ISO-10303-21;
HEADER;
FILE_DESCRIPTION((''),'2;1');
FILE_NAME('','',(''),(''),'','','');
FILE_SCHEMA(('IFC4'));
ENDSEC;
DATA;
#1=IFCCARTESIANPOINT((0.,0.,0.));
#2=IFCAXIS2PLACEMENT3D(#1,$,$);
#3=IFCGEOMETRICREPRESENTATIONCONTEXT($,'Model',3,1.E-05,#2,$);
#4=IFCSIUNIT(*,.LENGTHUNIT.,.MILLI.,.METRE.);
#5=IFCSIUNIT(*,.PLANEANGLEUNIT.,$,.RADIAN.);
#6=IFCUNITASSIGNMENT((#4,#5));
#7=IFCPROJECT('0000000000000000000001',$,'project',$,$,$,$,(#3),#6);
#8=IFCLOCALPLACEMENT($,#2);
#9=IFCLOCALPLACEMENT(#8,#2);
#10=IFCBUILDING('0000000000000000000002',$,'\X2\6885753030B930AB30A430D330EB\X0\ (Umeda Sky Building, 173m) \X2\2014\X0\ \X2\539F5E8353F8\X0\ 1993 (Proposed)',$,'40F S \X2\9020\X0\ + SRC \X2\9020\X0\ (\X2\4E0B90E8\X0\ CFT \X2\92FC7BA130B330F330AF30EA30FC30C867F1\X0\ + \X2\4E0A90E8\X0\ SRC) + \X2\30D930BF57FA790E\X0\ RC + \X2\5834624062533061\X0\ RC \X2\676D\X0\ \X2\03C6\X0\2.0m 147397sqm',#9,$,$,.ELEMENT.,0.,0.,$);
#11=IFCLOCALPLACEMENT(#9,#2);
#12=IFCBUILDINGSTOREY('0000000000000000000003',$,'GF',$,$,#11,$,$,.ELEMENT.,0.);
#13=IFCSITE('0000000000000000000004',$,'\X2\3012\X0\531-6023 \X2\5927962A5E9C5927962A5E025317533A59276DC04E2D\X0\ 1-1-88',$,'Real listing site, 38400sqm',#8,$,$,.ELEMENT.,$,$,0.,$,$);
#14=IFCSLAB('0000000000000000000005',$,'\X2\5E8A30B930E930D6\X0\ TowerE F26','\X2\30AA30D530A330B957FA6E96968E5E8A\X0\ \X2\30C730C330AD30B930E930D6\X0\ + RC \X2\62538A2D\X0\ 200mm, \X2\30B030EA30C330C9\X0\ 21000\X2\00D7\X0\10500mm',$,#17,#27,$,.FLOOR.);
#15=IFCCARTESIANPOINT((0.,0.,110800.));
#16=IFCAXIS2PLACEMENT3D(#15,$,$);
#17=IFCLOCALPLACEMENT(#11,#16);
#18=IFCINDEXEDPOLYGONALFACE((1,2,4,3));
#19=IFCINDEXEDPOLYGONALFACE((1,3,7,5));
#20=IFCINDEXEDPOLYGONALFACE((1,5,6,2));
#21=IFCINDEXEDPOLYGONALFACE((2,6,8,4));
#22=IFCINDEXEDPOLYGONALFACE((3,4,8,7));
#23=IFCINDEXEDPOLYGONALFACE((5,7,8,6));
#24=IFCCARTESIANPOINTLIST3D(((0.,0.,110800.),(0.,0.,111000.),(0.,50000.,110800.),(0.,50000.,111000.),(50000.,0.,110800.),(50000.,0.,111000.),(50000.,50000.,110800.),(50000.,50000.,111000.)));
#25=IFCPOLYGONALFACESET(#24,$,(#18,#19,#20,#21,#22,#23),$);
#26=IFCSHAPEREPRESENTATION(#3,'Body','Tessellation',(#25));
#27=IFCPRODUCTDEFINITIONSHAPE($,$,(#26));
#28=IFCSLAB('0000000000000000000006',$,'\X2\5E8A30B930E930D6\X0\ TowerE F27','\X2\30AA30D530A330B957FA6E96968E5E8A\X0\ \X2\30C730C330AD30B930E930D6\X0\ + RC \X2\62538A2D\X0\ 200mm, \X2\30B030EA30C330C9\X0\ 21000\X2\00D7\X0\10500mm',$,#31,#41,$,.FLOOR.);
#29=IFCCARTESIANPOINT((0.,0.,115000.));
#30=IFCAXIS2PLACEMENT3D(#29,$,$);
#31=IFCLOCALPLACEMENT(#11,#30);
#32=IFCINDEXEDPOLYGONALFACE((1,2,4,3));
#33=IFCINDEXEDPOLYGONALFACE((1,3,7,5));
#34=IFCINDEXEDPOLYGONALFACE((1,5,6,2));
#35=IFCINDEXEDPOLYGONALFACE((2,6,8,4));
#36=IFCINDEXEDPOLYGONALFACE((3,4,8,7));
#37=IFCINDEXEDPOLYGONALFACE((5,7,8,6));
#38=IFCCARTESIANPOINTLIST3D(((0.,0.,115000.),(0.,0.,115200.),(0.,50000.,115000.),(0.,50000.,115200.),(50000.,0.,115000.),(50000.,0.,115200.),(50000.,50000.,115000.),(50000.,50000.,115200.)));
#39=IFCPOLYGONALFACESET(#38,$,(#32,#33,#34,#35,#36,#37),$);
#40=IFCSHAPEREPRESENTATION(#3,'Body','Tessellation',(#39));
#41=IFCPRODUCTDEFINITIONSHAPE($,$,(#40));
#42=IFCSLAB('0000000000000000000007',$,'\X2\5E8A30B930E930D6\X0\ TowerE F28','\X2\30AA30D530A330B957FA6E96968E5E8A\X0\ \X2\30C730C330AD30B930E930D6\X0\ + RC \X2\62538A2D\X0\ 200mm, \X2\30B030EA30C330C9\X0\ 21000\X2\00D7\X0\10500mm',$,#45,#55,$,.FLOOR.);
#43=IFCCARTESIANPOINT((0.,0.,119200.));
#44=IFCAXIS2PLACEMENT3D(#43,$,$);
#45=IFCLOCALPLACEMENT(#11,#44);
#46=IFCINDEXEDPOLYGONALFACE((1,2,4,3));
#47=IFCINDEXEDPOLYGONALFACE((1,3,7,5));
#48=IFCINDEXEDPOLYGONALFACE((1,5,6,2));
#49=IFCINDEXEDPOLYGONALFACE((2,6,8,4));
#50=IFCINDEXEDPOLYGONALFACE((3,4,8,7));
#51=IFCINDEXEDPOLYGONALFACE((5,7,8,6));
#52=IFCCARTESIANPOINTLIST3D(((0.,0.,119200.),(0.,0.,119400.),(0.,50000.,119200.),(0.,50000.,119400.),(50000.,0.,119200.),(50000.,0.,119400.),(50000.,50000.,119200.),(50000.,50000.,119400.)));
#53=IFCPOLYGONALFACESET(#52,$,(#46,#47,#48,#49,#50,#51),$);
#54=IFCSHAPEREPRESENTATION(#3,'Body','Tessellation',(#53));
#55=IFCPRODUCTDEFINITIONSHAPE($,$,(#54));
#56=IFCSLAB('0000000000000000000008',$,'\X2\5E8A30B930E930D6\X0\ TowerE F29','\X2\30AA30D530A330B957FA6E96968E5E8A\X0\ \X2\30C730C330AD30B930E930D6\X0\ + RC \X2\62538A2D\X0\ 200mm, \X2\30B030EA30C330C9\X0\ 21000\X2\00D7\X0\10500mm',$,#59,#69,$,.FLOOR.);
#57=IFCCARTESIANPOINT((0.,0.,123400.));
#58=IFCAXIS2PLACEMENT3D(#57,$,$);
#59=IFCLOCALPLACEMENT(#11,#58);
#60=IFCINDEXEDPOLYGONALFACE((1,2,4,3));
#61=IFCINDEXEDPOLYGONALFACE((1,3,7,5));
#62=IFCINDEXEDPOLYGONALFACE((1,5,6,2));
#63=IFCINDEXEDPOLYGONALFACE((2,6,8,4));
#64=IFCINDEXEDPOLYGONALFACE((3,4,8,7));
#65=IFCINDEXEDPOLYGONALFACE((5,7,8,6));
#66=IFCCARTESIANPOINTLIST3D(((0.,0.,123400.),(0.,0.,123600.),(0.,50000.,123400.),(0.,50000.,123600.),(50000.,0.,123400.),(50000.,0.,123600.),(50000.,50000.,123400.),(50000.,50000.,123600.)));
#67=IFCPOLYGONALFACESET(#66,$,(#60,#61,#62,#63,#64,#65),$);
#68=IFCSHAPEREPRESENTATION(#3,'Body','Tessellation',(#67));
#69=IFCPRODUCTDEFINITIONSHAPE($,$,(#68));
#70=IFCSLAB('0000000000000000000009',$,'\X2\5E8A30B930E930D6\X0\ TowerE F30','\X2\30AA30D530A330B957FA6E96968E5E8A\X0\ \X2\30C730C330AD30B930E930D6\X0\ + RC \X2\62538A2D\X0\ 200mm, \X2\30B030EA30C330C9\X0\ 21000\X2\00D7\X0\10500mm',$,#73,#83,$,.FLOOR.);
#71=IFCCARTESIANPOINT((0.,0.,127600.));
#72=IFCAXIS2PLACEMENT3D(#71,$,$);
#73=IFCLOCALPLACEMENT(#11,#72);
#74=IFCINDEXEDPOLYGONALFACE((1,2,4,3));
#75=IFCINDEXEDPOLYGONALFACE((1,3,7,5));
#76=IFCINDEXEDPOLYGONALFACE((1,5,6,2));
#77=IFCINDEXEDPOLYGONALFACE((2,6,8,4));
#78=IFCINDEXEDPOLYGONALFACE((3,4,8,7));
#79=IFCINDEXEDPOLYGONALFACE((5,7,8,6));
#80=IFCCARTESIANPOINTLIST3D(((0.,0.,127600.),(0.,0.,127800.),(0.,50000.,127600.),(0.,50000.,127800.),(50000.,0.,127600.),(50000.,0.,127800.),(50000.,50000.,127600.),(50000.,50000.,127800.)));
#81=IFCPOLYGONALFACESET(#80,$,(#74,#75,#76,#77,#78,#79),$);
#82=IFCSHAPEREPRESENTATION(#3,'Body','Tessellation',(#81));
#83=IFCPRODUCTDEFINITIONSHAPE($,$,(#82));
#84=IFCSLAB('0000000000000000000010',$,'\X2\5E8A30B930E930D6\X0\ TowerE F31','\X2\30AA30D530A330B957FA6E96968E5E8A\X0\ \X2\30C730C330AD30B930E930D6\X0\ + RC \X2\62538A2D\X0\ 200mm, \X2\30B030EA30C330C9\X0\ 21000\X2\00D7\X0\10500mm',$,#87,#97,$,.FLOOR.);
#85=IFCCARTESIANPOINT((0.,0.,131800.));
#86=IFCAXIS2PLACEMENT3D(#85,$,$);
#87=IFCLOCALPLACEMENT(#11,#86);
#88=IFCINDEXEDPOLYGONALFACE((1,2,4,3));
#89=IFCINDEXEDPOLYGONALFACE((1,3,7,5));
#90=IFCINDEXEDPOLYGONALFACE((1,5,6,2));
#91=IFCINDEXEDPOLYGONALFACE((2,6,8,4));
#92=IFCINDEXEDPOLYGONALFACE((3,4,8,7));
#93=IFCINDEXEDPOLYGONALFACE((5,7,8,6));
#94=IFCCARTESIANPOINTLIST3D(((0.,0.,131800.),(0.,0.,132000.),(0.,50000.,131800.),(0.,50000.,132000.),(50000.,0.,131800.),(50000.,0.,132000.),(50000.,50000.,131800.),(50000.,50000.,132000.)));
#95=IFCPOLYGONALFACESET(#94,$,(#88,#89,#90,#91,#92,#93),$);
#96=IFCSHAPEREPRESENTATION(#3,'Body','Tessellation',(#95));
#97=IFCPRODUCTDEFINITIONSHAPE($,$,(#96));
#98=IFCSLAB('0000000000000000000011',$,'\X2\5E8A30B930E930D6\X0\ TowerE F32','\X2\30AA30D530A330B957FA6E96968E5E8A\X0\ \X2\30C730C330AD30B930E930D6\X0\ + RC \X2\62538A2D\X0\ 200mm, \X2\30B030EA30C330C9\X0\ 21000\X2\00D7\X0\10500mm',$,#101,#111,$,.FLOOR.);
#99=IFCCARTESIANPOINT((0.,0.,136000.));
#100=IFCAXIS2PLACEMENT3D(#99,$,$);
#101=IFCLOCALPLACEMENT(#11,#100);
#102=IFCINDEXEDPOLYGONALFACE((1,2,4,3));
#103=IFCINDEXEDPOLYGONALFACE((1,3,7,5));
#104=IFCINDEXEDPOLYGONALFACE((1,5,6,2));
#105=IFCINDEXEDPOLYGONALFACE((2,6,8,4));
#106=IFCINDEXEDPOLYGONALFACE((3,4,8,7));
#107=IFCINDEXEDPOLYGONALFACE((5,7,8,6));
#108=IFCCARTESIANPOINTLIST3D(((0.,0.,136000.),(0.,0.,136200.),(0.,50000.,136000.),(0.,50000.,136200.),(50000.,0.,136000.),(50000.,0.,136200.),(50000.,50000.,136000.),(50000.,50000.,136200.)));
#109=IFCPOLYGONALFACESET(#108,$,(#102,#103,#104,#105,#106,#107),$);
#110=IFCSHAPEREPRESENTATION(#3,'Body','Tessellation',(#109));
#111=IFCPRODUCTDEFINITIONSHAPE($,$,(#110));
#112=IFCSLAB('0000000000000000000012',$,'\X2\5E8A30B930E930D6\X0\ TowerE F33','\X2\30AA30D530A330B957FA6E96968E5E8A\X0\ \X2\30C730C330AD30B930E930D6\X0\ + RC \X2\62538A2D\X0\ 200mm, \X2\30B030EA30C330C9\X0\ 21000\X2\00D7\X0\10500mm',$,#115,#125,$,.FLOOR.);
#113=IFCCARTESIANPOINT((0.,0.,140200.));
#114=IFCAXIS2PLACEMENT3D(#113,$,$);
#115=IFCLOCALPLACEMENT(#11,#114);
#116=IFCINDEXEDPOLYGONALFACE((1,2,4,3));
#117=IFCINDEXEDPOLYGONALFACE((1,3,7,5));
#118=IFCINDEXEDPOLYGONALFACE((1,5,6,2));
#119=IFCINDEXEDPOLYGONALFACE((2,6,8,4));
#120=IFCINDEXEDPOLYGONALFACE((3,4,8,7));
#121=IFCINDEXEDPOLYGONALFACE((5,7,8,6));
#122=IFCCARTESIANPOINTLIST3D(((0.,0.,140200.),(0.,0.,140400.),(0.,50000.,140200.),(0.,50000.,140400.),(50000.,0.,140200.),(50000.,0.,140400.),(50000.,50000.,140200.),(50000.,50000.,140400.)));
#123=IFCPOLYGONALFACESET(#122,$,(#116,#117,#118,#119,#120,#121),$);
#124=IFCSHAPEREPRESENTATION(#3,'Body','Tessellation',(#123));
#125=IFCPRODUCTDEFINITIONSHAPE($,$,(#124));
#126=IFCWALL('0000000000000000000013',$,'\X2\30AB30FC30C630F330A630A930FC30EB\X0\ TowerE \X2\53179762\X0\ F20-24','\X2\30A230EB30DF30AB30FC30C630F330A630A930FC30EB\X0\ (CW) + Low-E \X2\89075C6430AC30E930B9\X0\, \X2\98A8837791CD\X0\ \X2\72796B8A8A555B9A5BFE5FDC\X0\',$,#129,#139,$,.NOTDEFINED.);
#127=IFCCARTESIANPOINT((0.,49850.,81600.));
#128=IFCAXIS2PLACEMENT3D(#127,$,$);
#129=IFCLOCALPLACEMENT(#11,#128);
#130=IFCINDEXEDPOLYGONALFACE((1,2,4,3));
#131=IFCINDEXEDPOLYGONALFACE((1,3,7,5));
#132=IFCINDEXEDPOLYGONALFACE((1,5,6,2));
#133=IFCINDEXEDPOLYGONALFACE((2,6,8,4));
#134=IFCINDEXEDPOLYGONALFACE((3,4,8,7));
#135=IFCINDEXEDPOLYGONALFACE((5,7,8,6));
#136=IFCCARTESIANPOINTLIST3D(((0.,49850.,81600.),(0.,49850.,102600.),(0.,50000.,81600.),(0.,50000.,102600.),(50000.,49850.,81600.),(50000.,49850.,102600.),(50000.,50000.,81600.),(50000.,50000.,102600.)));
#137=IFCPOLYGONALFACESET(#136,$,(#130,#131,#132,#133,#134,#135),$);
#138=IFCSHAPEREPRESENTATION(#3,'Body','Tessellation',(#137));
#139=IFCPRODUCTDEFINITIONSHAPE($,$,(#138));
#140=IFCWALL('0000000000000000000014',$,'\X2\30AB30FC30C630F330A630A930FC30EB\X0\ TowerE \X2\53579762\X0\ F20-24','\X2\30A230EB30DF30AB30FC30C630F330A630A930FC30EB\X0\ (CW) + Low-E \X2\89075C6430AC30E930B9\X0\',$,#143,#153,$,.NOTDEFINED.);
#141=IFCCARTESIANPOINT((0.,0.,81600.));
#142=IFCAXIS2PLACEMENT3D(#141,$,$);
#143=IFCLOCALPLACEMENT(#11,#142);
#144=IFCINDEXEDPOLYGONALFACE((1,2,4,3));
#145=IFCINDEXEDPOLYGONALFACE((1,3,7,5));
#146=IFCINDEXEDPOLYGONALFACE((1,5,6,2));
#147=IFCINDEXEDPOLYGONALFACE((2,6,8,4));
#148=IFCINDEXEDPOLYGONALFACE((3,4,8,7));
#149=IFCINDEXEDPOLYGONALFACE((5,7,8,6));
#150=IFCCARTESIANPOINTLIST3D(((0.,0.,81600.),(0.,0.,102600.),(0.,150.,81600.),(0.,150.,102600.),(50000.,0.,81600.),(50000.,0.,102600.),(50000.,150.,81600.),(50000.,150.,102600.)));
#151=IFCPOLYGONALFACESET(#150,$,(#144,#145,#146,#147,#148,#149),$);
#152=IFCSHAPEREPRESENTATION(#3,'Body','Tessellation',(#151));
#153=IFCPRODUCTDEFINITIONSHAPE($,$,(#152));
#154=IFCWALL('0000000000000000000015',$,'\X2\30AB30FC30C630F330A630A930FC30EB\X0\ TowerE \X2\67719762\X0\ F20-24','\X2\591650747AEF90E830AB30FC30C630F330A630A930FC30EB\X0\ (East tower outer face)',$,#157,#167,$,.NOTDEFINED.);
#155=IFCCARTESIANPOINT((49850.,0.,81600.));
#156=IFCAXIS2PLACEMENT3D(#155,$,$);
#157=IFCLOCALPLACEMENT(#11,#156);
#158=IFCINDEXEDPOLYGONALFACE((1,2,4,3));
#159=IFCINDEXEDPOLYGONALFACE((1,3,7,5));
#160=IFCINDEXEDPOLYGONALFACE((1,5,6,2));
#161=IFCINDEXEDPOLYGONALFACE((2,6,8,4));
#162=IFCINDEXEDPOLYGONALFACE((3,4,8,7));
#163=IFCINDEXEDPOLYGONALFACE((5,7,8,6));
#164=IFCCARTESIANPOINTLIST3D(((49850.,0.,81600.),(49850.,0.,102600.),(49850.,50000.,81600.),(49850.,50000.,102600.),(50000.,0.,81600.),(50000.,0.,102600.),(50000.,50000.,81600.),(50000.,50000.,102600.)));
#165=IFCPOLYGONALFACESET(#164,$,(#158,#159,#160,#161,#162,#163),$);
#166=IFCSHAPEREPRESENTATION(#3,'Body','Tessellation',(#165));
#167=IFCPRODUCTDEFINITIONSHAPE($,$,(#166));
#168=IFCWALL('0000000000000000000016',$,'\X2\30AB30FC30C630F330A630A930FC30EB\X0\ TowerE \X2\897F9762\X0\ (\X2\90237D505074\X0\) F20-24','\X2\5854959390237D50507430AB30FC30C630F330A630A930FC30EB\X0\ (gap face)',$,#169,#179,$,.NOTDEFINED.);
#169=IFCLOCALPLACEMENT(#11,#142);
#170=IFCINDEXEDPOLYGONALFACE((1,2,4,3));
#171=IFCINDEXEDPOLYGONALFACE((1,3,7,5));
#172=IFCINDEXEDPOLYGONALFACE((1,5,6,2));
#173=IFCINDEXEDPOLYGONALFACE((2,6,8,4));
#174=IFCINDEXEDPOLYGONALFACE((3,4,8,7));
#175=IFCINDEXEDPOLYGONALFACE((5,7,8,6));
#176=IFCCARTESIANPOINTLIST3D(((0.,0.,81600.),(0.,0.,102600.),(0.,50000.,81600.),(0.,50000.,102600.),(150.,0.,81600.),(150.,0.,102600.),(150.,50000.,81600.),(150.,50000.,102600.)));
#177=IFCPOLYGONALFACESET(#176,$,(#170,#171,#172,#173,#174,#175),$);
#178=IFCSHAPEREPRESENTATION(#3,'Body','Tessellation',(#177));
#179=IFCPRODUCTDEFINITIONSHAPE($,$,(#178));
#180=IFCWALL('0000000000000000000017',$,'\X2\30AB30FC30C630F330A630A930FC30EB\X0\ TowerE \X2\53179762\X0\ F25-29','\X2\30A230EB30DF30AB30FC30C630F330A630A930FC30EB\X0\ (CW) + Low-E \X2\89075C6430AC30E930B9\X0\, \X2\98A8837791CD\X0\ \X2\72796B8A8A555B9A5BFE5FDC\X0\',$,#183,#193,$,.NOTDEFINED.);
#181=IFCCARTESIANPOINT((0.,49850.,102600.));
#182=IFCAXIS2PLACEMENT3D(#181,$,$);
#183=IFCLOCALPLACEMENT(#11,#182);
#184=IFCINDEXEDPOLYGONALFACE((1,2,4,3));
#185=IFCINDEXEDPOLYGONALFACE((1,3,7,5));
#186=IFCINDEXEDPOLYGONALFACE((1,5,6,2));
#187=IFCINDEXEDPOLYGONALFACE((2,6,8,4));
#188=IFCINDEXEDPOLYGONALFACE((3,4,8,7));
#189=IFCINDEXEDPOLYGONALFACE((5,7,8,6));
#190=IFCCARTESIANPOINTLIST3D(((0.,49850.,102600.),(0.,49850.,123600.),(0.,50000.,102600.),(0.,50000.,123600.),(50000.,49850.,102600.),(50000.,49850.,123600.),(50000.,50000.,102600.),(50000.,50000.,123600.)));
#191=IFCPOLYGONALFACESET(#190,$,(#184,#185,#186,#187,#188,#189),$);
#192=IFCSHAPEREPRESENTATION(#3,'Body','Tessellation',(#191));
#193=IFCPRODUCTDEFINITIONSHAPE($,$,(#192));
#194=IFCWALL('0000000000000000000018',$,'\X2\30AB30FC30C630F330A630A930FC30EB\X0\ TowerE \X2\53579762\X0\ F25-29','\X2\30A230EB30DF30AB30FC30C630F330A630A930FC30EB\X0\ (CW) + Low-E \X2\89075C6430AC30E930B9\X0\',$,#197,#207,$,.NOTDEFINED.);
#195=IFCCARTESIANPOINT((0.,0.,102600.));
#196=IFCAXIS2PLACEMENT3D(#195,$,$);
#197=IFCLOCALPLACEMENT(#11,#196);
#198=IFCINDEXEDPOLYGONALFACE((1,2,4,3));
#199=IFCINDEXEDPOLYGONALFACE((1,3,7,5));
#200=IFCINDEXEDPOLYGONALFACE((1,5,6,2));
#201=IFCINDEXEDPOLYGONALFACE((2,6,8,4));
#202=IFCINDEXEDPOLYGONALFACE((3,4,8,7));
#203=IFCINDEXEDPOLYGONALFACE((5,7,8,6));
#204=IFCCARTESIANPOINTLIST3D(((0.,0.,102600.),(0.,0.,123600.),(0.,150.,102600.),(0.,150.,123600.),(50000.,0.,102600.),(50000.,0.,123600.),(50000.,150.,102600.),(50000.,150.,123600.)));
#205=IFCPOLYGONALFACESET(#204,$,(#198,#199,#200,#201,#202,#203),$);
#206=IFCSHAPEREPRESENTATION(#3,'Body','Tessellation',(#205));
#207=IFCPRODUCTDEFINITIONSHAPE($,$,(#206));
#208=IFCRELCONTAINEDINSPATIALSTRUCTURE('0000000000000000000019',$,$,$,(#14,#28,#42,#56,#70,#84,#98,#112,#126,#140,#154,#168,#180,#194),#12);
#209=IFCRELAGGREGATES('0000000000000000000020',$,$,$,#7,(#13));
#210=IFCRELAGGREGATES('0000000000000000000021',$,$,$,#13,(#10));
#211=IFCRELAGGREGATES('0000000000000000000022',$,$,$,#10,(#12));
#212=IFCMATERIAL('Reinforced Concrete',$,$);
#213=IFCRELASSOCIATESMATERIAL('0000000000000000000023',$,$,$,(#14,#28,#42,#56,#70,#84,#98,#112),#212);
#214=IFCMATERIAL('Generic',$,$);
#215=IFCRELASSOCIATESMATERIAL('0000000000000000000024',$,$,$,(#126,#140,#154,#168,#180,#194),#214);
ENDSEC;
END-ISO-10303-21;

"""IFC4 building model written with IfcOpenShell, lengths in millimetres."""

from ifc_helpers import new_model, si_unit, frame, frame_2d, origin, place, context, project, spatial, rectangle, extrude, material, element, save


model = new_model("IFC4")

# Units and contexts
model_context = context("Model", 3, precision=1e-05, world=origin())
ifc_project = project(units=[si_unit("LENGTHUNIT", "METRE", prefix="MILLI"), si_unit("PLANEANGLEUNIT", "RADIAN")], contexts=[model_context])

# Site, building, storey
site_placement = place(None, origin())
site = spatial("IfcSite", under=ifc_project, at=site_placement, Name="〒531-6023 大阪府大阪市北区大淀中 1-1-88", ObjectType="Real listing site, 38400sqm", CompositionType="ELEMENT", RefElevation=0.0)
building_placement = place(site_placement, origin())
building = spatial("IfcBuilding", under=site, at=building_placement, Name="梅田スカイビル (Umeda Sky Building, 173m) — 原広司 1993 (Proposed)", ObjectType="40F S 造 + SRC 造 (下部 CFT 鋼管コンクリート柱 + 上部 SRC) + ベタ基礎 RC + 場所打ち RC 杭 φ2.0m 147397sqm", CompositionType="ELEMENT", ElevationOfRefHeight=0.0, ElevationOfTerrain=0.0)
storey_placement = place(building_placement, origin())
storey = spatial("IfcBuildingStorey", under=building, at=storey_placement, Name="GF", CompositionType="ELEMENT", Elevation=0.0)

# Shared definitions
ifc_material_1 = material(Name="Reinforced Concrete")

# Slabs
slab_1_placement = place(storey_placement, frame((0.0, 0.0, 110800.0)))
element("IfcSlab", 1, at=slab_1_placement, inside=storey, material=ifc_material_1, Name="床スラブ TowerE F26", Description="オフィス基準階床 デッキスラブ + RC 打設 200mm, グリッド 21000×10500mm", PredefinedType="FLOOR", context=model_context, shape_type="SweptSolid", body=[
    extrude(rectangle(XDim=50000.0, YDim=50000.0, at=frame_2d((25000.0, 25000.0))), frame((0.0, 0.0, 110800.0)), (0.0, 0.0, 1.0), 200.0),
])
slab_2_placement = place(storey_placement, frame((0.0, 0.0, 115000.0)))
element("IfcSlab", 2, at=slab_2_placement, inside=storey, material=ifc_material_1, Name="床スラブ TowerE F27", Description="オフィス基準階床 デッキスラブ + RC 打設 200mm, グリッド 21000×10500mm", PredefinedType="FLOOR", context=model_context, shape_type="SweptSolid", body=[
    extrude(rectangle(XDim=50000.0, YDim=50000.0, at=frame_2d((25000.0, 25000.0))), frame((0.0, 0.0, 115000.0)), (0.0, 0.0, 1.0), 200.0),
])
slab_3_placement = place(storey_placement, frame((0.0, 0.0, 119200.0)))
element("IfcSlab", 3, at=slab_3_placement, inside=storey, material=ifc_material_1, Name="床スラブ TowerE F28", Description="オフィス基準階床 デッキスラブ + RC 打設 200mm, グリッド 21000×10500mm", PredefinedType="FLOOR", context=model_context, shape_type="SweptSolid", body=[
    extrude(rectangle(XDim=50000.0, YDim=50000.0, at=frame_2d((25000.0, 25000.0))), frame((0.0, 0.0, 119200.0)), (0.0, 0.0, 1.0), 200.0),
])
slab_4_placement = place(storey_placement, frame((0.0, 0.0, 123400.0)))
element("IfcSlab", 4, at=slab_4_placement, inside=storey, material=ifc_material_1, Name="床スラブ TowerE F29", Description="オフィス基準階床 デッキスラブ + RC 打設 200mm, グリッド 21000×10500mm", PredefinedType="FLOOR", context=model_context, shape_type="SweptSolid", body=[
    extrude(rectangle(XDim=50000.0, YDim=50000.0, at=frame_2d((25000.0, 25000.0))), frame((0.0, 0.0, 123400.0)), (0.0, 0.0, 1.0), 200.0),
])
slab_5_placement = place(storey_placement, frame((0.0, 0.0, 127600.0)))
element("IfcSlab", 5, at=slab_5_placement, inside=storey, material=ifc_material_1, Name="床スラブ TowerE F30", Description="オフィス基準階床 デッキスラブ + RC 打設 200mm, グリッド 21000×10500mm", PredefinedType="FLOOR", context=model_context, shape_type="SweptSolid", body=[
    extrude(rectangle(XDim=50000.0, YDim=50000.0, at=frame_2d((25000.0, 25000.0))), frame((0.0, 0.0, 127600.0)), (0.0, 0.0, 1.0), 200.0),
])
slab_6_placement = place(storey_placement, frame((0.0, 0.0, 131800.0)))
element("IfcSlab", 6, at=slab_6_placement, inside=storey, material=ifc_material_1, Name="床スラブ TowerE F31", Description="オフィス基準階床 デッキスラブ + RC 打設 200mm, グリッド 21000×10500mm", PredefinedType="FLOOR", context=model_context, shape_type="SweptSolid", body=[
    extrude(rectangle(XDim=50000.0, YDim=50000.0, at=frame_2d((25000.0, 25000.0))), frame((0.0, 0.0, 131800.0)), (0.0, 0.0, 1.0), 200.0),
])
slab_7_placement = place(storey_placement, frame((0.0, 0.0, 136000.0)))
element("IfcSlab", 7, at=slab_7_placement, inside=storey, material=ifc_material_1, Name="床スラブ TowerE F32", Description="オフィス基準階床 デッキスラブ + RC 打設 200mm, グリッド 21000×10500mm", PredefinedType="FLOOR", context=model_context, shape_type="SweptSolid", body=[
    extrude(rectangle(XDim=50000.0, YDim=50000.0, at=frame_2d((25000.0, 25000.0))), frame((0.0, 0.0, 136000.0)), (0.0, 0.0, 1.0), 200.0),
])
slab_8_placement = place(storey_placement, frame((0.0, 0.0, 140200.0)))
element("IfcSlab", 8, at=slab_8_placement, inside=storey, material=ifc_material_1, Name="床スラブ TowerE F33", Description="オフィス基準階床 デッキスラブ + RC 打設 200mm, グリッド 21000×10500mm", PredefinedType="FLOOR", context=model_context, shape_type="SweptSolid", body=[
    extrude(rectangle(XDim=50000.0, YDim=50000.0, at=frame_2d((25000.0, 25000.0))), frame((0.0, 0.0, 140200.0)), (0.0, 0.0, 1.0), 200.0),
])

# Walls
ifc_material_2 = material(Name="Generic")
wall_1_placement = place(storey_placement, frame((0.0, 49850.0, 81600.0)))
element("IfcWall", 9, at=wall_1_placement, inside=storey, material=ifc_material_2, Name="カーテンウォール TowerE 北面 F20-24", Description="アルミカーテンウォール (CW) + Low-E 複層ガラス, 風荷重 特殊評定対応", PredefinedType="NOTDEFINED", context=model_context, shape_type="SweptSolid", body=[
    extrude(rectangle(XDim=50000.0, YDim=150.0, at=frame_2d((25000.0, 75.0))), frame((0.0, 49850.0, 81600.0)), (0.0, 0.0, 1.0), 21000.0),
])
wall_2_placement = place(storey_placement, frame((0.0, 0.0, 81600.0)))
element("IfcWall", 10, at=wall_2_placement, inside=storey, material=ifc_material_2, Name="カーテンウォール TowerE 南面 F20-24", Description="アルミカーテンウォール (CW) + Low-E 複層ガラス", PredefinedType="NOTDEFINED", context=model_context, shape_type="SweptSolid", body=[
    extrude(rectangle(XDim=50000.0, YDim=150.0, at=frame_2d((25000.0, 75.0))), frame((0.0, 0.0, 81600.0)), (0.0, 0.0, 1.0), 21000.0),
])
wall_3_placement = place(storey_placement, frame((49850.0, 0.0, 81600.0)))
element("IfcWall", 11, at=wall_3_placement, inside=storey, material=ifc_material_2, Name="カーテンウォール TowerE 東面 F20-24", Description="外側端部カーテンウォール (East tower outer face)", PredefinedType="NOTDEFINED", context=model_context, shape_type="SweptSolid", body=[
    extrude(rectangle(XDim=150.0, YDim=50000.0, at=frame_2d((75.0, 25000.0))), frame((49850.0, 0.0, 81600.0)), (0.0, 0.0, 1.0), 21000.0),
])
wall_4_placement = place(storey_placement, frame((0.0, 0.0, 81600.0)))
element("IfcWall", 12, at=wall_4_placement, inside=storey, material=ifc_material_2, Name="カーテンウォール TowerE 西面 (連結側) F20-24", Description="塔間連結側カーテンウォール (gap face)", PredefinedType="NOTDEFINED", context=model_context, shape_type="SweptSolid", body=[
    extrude(rectangle(XDim=150.0, YDim=50000.0, at=frame_2d((75.0, 25000.0))), frame((0.0, 0.0, 81600.0)), (0.0, 0.0, 1.0), 21000.0),
])
wall_5_placement = place(storey_placement, frame((0.0, 49850.0, 102600.0)))
element("IfcWall", 13, at=wall_5_placement, inside=storey, material=ifc_material_2, Name="カーテンウォール TowerE 北面 F25-29", Description="アルミカーテンウォール (CW) + Low-E 複層ガラス, 風荷重 特殊評定対応", PredefinedType="NOTDEFINED", context=model_context, shape_type="SweptSolid", body=[
    extrude(rectangle(XDim=50000.0, YDim=150.0, at=frame_2d((25000.0, 75.0))), frame((0.0, 49850.0, 102600.0)), (0.0, 0.0, 1.0), 21000.0),
])
wall_6_placement = place(storey_placement, frame((0.0, 0.0, 102600.0)))
element("IfcWall", 14, at=wall_6_placement, inside=storey, material=ifc_material_2, Name="カーテンウォール TowerE 南面 F25-29", Description="アルミカーテンウォール (CW) + Low-E 複層ガラス", PredefinedType="NOTDEFINED", context=model_context, shape_type="SweptSolid", body=[
    extrude(rectangle(XDim=50000.0, YDim=150.0, at=frame_2d((25000.0, 75.0))), frame((0.0, 0.0, 102600.0)), (0.0, 0.0, 1.0), 21000.0),
])

save(model, "model.ifc")
